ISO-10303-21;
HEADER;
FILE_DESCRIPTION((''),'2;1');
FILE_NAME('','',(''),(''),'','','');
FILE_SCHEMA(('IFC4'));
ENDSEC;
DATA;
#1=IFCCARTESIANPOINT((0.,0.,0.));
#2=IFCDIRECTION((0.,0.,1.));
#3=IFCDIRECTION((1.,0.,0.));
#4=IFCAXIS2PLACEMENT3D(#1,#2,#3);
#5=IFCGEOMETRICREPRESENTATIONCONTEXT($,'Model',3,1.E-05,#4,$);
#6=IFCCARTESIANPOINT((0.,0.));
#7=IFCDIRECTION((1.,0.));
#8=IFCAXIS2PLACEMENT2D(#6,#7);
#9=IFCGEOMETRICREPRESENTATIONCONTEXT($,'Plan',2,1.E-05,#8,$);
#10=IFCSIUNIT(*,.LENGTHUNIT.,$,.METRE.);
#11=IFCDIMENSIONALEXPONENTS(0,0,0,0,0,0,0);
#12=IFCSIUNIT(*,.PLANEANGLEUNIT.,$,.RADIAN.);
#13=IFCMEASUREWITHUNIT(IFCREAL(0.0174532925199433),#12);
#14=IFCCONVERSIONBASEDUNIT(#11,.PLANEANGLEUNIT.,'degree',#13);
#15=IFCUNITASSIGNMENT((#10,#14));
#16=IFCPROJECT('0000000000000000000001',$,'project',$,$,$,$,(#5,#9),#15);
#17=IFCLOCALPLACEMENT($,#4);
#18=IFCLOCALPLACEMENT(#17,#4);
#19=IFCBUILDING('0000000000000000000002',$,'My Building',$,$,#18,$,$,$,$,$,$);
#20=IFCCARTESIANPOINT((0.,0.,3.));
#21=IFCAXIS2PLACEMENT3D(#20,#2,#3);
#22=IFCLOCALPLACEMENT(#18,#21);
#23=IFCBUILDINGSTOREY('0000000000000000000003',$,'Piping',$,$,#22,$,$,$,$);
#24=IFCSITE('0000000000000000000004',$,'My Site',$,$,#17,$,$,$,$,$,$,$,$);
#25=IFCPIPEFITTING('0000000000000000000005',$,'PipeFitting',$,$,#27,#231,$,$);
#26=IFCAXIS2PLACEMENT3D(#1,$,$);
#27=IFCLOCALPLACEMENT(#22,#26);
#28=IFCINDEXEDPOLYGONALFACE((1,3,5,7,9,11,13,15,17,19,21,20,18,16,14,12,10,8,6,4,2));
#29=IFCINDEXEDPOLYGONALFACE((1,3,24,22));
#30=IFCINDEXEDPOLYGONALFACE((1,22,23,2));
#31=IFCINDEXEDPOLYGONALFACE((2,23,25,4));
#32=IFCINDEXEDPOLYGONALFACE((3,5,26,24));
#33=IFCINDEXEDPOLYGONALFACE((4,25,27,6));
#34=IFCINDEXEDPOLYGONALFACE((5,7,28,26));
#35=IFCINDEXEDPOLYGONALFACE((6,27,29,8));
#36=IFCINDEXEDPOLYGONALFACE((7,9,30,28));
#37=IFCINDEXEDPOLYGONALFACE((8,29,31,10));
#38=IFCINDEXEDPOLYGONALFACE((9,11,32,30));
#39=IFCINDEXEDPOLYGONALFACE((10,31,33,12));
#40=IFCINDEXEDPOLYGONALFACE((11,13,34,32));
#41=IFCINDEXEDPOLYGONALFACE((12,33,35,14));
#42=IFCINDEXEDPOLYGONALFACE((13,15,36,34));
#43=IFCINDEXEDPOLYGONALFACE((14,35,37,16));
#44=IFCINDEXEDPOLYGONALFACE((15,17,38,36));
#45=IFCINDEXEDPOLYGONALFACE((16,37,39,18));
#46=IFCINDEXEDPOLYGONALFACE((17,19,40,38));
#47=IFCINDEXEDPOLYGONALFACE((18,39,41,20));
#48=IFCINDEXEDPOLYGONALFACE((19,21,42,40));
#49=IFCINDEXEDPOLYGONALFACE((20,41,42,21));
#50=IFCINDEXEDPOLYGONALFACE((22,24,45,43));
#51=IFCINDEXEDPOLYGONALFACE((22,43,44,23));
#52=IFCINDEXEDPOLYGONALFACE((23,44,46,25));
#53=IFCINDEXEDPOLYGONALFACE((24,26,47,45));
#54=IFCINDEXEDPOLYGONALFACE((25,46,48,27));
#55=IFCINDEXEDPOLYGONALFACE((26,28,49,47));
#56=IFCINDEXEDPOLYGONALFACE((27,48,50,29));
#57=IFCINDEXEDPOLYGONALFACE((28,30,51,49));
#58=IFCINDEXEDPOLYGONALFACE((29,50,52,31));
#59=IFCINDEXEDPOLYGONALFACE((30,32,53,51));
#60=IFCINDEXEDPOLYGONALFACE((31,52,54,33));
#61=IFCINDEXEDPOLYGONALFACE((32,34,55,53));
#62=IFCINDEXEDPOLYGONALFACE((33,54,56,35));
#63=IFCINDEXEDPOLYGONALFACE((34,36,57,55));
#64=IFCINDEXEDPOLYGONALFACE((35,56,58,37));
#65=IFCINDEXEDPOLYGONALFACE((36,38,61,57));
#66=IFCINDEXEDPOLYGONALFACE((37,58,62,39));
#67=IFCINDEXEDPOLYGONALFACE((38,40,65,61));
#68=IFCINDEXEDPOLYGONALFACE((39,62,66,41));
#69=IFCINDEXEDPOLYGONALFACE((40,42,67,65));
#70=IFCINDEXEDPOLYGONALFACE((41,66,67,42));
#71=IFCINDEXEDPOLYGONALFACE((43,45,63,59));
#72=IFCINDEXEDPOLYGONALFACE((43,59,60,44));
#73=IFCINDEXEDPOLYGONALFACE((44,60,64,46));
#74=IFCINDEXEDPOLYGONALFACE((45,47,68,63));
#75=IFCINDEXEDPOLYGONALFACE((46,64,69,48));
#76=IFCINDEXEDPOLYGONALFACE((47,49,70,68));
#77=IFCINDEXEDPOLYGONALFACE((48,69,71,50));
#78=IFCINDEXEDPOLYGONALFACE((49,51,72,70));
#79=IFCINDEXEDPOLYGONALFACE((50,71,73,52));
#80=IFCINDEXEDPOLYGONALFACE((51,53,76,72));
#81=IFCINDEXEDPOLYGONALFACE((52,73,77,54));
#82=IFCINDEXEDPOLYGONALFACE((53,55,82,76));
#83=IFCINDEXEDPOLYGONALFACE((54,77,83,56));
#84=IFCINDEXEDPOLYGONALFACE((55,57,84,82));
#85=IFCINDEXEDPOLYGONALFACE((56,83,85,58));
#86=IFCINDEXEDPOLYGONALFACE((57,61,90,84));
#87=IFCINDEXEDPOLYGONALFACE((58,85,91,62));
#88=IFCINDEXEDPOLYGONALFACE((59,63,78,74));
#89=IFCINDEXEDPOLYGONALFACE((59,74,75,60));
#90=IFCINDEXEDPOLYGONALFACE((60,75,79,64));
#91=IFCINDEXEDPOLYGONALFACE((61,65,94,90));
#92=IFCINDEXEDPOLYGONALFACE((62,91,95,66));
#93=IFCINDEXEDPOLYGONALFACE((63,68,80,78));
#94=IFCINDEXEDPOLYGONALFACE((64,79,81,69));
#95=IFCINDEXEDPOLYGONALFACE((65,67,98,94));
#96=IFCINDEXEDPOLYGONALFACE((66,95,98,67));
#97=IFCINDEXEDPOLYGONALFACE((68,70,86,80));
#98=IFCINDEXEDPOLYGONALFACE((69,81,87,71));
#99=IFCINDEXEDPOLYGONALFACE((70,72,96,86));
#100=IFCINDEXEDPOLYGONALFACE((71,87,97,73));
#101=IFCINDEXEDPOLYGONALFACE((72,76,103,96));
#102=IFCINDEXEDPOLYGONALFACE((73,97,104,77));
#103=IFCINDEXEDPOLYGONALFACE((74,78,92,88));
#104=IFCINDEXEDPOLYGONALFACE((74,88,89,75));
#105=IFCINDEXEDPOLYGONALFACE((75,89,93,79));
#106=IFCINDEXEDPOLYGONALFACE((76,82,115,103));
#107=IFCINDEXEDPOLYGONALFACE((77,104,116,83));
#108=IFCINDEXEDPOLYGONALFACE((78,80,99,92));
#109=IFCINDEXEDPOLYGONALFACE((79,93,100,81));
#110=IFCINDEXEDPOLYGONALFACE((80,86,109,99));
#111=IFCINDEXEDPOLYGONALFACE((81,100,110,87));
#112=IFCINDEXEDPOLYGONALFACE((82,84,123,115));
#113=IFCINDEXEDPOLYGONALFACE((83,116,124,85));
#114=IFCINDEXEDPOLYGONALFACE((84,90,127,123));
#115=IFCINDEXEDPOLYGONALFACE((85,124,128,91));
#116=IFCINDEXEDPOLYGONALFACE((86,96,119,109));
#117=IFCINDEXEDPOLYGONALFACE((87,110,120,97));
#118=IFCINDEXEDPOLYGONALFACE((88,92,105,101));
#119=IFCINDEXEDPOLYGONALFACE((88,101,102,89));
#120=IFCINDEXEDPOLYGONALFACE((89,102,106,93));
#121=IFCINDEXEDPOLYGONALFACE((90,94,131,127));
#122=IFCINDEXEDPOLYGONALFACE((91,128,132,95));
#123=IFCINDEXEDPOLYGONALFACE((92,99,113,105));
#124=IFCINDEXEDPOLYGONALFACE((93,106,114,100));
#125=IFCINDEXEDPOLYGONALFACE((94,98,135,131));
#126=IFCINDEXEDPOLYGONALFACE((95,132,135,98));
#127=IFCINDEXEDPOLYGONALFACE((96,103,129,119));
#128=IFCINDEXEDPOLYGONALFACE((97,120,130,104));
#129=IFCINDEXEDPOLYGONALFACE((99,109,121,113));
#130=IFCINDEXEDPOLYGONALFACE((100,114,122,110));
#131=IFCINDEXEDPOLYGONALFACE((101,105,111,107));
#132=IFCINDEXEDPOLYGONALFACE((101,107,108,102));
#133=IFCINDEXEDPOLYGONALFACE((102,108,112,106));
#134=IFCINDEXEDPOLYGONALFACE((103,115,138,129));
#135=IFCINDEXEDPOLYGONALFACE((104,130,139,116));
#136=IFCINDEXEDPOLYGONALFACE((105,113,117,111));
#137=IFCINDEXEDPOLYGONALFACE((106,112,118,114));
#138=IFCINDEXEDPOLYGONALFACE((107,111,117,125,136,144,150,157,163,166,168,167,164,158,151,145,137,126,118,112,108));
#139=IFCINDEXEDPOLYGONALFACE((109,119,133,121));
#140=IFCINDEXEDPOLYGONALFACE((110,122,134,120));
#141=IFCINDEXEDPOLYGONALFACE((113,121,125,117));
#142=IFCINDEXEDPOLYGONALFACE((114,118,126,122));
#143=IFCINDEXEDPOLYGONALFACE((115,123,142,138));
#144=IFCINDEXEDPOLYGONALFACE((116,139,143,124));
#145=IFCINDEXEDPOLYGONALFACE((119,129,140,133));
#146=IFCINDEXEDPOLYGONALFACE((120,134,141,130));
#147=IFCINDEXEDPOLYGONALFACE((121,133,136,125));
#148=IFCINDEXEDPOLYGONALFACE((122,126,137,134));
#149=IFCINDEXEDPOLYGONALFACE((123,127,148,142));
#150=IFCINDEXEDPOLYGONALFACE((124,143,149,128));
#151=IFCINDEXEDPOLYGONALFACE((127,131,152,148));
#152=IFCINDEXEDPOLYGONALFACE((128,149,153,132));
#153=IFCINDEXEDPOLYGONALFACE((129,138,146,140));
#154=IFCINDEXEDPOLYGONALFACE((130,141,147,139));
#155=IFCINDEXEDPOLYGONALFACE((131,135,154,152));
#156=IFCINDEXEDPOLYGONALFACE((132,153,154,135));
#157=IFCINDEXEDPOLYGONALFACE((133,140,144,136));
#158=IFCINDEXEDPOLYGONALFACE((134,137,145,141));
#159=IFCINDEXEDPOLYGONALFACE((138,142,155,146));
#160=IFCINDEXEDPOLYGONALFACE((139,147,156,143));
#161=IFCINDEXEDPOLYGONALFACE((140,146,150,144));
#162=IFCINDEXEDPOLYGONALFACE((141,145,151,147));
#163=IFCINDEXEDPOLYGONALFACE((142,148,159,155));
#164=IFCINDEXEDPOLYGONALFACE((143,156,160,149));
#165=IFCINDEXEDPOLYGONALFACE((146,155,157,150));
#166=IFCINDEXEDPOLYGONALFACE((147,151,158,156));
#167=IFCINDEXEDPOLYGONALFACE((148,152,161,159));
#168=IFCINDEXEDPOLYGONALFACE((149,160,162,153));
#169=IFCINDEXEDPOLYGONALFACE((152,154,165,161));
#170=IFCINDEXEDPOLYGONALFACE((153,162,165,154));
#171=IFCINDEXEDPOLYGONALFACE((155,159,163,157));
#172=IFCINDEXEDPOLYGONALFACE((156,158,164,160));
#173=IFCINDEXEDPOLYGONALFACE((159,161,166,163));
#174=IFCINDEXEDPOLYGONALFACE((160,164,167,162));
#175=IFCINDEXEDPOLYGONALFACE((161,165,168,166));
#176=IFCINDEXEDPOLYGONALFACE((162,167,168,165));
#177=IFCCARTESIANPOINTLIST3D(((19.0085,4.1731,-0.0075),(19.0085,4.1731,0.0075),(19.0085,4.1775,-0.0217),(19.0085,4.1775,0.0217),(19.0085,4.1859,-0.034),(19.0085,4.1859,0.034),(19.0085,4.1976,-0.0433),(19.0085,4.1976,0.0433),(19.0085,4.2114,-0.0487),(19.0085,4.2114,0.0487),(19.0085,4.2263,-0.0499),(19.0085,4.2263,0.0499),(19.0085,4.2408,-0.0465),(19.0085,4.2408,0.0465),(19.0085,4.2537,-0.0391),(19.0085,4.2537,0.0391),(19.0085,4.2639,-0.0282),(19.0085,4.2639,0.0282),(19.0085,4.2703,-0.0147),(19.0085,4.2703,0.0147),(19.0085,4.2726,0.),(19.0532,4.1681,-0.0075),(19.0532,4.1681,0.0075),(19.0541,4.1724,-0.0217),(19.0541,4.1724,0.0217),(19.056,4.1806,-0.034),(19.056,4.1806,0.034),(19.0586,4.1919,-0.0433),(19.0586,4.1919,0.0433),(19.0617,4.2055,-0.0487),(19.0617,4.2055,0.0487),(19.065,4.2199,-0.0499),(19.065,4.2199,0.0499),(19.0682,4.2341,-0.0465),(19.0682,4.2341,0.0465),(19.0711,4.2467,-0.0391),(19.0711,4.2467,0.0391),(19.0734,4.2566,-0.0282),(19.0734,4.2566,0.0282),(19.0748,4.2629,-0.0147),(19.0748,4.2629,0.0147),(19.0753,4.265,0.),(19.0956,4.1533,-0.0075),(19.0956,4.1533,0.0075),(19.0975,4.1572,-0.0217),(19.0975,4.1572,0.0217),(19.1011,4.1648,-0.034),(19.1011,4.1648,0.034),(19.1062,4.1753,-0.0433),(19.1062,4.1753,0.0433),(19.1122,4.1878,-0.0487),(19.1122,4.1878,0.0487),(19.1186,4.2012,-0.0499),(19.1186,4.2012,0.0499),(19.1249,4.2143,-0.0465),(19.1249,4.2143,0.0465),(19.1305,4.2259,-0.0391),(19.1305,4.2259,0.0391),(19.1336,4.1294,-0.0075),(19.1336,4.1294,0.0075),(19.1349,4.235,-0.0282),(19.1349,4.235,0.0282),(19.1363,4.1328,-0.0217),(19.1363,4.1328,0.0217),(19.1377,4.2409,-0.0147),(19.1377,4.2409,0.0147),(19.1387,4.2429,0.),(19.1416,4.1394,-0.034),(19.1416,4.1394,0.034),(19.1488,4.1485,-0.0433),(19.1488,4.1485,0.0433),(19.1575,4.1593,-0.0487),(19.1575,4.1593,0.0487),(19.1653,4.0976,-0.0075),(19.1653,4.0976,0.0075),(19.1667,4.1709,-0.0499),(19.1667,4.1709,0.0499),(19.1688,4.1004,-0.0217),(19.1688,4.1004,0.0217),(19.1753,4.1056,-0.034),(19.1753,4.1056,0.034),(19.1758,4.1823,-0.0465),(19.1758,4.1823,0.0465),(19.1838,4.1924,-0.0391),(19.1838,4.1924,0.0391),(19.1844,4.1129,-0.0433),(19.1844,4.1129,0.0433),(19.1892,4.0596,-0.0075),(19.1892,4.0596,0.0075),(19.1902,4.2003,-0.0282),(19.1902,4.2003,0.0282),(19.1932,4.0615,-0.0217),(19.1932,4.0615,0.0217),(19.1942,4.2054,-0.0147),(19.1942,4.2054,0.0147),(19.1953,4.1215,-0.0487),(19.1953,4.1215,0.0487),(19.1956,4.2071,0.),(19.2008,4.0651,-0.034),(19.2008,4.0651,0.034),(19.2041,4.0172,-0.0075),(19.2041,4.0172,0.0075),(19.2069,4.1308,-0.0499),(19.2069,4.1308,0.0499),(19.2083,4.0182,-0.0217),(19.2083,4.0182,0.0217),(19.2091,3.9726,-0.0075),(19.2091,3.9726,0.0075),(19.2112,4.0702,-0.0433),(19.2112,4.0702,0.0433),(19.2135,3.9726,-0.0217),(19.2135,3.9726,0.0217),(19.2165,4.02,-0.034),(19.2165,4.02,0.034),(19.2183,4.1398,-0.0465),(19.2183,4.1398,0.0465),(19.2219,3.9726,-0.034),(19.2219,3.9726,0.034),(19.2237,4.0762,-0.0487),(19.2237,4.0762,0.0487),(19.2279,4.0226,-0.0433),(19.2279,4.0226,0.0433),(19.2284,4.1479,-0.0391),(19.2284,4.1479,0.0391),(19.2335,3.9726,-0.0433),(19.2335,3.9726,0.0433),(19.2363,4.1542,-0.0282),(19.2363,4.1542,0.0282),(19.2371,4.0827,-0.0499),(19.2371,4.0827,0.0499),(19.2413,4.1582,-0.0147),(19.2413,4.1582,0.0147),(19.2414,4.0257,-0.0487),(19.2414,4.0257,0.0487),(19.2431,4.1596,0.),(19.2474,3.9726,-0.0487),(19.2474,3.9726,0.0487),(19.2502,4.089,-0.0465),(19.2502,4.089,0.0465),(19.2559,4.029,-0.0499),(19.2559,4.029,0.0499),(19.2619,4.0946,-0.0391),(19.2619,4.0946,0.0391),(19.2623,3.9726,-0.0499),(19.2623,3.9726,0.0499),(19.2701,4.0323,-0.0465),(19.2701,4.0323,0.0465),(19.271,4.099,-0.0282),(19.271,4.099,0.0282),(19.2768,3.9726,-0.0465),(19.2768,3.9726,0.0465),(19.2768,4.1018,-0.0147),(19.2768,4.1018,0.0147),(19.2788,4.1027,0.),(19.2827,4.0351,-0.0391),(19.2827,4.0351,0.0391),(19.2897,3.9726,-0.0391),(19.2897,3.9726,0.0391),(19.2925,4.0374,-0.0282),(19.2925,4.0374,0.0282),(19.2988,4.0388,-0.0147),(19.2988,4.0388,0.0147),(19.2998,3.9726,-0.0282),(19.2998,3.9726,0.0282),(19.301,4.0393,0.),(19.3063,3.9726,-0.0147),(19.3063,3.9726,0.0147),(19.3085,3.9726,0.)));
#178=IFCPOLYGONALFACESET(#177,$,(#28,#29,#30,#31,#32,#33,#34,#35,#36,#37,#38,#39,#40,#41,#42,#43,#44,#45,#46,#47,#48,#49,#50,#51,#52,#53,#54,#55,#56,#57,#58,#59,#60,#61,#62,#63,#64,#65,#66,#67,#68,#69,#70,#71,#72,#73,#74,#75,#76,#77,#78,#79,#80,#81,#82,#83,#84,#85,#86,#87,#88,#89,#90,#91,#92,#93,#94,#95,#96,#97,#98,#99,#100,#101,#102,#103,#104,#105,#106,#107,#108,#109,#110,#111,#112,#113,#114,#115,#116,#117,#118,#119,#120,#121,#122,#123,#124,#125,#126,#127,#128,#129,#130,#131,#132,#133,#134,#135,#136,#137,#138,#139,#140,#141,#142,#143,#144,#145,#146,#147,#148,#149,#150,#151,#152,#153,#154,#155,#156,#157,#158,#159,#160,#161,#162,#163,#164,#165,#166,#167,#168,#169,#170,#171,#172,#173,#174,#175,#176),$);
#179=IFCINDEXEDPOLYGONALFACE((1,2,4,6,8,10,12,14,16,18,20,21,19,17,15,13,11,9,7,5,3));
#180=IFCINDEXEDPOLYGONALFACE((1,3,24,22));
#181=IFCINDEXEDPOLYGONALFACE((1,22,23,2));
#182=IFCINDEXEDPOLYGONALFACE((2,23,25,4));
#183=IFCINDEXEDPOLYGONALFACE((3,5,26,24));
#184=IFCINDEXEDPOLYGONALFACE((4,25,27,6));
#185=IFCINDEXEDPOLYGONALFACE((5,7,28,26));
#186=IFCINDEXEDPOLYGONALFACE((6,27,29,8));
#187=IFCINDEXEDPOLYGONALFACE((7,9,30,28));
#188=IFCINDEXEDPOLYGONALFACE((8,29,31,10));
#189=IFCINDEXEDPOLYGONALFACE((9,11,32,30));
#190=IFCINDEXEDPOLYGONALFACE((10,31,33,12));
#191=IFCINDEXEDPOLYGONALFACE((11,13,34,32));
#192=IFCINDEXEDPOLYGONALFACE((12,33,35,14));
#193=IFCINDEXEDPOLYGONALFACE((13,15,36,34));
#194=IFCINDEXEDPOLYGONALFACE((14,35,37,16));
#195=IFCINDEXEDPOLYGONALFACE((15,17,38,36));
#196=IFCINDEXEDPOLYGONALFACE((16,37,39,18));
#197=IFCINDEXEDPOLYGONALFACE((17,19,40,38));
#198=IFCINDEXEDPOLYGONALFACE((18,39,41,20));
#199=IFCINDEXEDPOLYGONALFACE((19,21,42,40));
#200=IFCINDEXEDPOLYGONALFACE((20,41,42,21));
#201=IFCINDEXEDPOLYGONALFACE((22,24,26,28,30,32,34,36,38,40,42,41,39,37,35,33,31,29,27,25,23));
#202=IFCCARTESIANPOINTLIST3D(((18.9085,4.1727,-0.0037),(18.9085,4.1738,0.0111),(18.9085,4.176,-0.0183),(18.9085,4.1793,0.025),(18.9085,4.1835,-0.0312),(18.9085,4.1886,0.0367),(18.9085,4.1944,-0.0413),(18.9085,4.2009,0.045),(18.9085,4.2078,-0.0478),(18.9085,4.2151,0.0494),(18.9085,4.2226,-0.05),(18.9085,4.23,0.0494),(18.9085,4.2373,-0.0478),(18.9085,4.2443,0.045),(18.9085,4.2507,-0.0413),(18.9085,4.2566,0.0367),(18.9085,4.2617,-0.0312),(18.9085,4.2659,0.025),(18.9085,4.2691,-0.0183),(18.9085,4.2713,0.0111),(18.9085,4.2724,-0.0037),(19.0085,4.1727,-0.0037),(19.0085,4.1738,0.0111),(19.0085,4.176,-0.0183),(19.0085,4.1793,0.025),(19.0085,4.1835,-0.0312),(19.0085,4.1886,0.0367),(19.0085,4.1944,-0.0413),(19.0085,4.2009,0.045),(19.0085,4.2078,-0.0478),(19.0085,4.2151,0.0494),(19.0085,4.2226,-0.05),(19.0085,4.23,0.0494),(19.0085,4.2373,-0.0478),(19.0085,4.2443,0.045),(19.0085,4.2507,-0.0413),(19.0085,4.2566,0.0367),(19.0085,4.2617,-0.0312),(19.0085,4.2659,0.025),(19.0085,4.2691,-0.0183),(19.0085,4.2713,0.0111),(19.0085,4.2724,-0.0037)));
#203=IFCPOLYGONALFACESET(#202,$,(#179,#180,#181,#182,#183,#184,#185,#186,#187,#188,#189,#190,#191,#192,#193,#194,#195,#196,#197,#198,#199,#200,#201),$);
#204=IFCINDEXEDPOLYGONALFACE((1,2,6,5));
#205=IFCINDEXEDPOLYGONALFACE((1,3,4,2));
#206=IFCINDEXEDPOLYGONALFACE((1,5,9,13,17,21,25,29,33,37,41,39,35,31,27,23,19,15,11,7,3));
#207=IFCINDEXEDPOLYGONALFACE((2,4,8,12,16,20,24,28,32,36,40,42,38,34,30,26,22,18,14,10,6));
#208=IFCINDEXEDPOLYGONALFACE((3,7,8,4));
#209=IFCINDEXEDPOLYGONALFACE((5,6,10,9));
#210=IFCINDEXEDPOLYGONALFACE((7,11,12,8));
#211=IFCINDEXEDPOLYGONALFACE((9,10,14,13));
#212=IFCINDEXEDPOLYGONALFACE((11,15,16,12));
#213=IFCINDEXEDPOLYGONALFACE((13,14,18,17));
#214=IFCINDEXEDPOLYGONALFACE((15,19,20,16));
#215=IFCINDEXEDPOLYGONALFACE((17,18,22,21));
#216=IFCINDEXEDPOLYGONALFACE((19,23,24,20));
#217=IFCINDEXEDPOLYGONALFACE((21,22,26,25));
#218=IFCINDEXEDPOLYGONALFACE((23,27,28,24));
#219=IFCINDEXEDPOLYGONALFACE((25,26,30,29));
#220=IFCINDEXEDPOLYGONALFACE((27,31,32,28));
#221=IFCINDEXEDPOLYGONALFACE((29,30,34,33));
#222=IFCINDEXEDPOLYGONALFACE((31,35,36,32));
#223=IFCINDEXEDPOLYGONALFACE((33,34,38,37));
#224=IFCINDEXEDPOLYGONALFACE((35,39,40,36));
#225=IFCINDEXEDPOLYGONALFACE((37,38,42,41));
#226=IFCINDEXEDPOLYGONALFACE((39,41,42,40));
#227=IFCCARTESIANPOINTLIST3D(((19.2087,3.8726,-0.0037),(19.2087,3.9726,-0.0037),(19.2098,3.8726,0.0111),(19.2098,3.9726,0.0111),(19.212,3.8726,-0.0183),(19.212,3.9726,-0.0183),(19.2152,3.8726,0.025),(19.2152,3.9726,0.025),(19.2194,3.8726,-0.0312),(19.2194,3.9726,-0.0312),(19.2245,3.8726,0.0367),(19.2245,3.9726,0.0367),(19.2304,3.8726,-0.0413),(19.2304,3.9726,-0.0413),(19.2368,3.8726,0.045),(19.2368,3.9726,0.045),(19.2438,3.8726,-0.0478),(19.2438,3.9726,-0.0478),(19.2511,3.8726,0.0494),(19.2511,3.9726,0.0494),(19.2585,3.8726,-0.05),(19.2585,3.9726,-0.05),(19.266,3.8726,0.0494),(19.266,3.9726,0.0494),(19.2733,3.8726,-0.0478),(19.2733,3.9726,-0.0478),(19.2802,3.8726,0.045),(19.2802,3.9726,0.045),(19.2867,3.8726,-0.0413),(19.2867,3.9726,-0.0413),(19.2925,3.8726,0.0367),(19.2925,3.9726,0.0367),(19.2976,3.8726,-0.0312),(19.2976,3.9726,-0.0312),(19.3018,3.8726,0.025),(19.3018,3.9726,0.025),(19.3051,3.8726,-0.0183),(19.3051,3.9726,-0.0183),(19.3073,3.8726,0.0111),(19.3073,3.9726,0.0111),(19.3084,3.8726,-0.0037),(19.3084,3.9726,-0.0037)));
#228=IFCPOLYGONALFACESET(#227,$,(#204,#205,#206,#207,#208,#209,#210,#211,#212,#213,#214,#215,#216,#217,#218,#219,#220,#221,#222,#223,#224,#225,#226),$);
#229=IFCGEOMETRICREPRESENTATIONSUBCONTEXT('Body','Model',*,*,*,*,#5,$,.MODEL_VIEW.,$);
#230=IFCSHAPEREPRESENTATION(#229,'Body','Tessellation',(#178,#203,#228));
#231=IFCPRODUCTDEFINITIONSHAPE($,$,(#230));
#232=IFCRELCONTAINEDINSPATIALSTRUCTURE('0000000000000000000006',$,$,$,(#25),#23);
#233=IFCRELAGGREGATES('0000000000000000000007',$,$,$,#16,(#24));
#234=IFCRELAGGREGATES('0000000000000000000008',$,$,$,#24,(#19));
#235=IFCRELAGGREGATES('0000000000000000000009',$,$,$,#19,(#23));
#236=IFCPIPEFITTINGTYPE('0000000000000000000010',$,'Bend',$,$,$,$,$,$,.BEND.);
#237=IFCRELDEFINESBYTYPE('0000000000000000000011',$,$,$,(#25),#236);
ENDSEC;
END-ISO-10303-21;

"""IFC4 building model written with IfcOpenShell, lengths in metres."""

from ifc_helpers import new_model, entity, si_unit, converted_unit, frame, origin_with_axes, origin_2d_with_axis, place, context, subcontext, project, spatial, circle, extrude, source, transform, mapped, type_object, type_shapes, element, save


model = new_model("IFC4")

# Units and contexts
model_context = context("Model", 3, precision=1e-05, world=origin_with_axes())
plan_context = context("Plan", 2, precision=1e-05, world=origin_2d_with_axis())
body_context = subcontext(model_context, "Body", "Model", "MODEL_VIEW")
ifc_project = project(units=[si_unit("LENGTHUNIT", "METRE"), converted_unit("PLANEANGLEUNIT", "degree", entity("IfcReal", 0.0174532925199433), si_unit("PLANEANGLEUNIT", "RADIAN"), dimensions=[0, 0, 0, 0, 0, 0, 0])], contexts=[model_context, plan_context])

# Site, building, storey
site_placement = place(None, origin_with_axes())
site = spatial("IfcSite", under=ifc_project, at=site_placement, Name="My Site")
building_placement = place(site_placement, origin_with_axes())
building = spatial("IfcBuilding", under=site, at=building_placement, Name="My Building")
storey_placement = place(building_placement, frame((0.0, 0.0, 3.0), z_axis=(0.0, 0.0, 1.0), x_axis=(1.0, 0.0, 0.0)))
storey = spatial("IfcBuildingStorey", under=building, at=storey_placement, Name="Piping")

# Shared definitions
pipe_fitting_type = type_object("IfcPipeFittingType", Name="Bend", PredefinedType="BEND")
shared_shape = source(origin_with_axes(), body_context, "Body", "SolidModel", [
    entity("IfcSweptDiskSolid", entity("IfcIndexedPolyCurve", entity("IfcCartesianPointList3D", [[0.0, 0.0, -0.1], [0.0, 0.0732, -0.2768], [0.0, 0.25, -0.35]]), [entity("IfcArcIndex", [1, 2, 3])]), 0.05),
    extrude(circle(Radius=0.05), origin_with_axes(), (0.0, 0.0, -1.0), 0.1),
    extrude(circle(Radius=0.05), frame((0.0, 0.25, -0.35), z_axis=(0.0, 1.0, 0.0), x_axis=(1.0, 0.0, 0.0)), (0.0, 0.0, 1.0), 0.1),
])
type_shapes(pipe_fitting_type, [shared_shape])

# Pipe fitting
for number, where, z_axis, x_axis, name in (
    (1, (18.9085, 4.2226, 0.0), (-1.0, 0.0, 0.0), (0.0, 0.0, -1.0), "PipeFitting"),
):
    element("IfcPipeFitting", number, at=place(storey_placement, frame(where, z_axis=z_axis, x_axis=x_axis)), inside=storey, type_object=pipe_fitting_type, Name=name, context=body_context, shape_type="MappedRepresentation", body=[
        mapped(shared_shape, transform((0.0, 0.0, 0.0), x_axis=(1.0, 0.0, 0.0), y_axis=(0.0, 1.0, 0.0), z_axis=(0.0, 0.0, 1.0), scale=1.0)),
    ])

save(model, "model.ifc")
